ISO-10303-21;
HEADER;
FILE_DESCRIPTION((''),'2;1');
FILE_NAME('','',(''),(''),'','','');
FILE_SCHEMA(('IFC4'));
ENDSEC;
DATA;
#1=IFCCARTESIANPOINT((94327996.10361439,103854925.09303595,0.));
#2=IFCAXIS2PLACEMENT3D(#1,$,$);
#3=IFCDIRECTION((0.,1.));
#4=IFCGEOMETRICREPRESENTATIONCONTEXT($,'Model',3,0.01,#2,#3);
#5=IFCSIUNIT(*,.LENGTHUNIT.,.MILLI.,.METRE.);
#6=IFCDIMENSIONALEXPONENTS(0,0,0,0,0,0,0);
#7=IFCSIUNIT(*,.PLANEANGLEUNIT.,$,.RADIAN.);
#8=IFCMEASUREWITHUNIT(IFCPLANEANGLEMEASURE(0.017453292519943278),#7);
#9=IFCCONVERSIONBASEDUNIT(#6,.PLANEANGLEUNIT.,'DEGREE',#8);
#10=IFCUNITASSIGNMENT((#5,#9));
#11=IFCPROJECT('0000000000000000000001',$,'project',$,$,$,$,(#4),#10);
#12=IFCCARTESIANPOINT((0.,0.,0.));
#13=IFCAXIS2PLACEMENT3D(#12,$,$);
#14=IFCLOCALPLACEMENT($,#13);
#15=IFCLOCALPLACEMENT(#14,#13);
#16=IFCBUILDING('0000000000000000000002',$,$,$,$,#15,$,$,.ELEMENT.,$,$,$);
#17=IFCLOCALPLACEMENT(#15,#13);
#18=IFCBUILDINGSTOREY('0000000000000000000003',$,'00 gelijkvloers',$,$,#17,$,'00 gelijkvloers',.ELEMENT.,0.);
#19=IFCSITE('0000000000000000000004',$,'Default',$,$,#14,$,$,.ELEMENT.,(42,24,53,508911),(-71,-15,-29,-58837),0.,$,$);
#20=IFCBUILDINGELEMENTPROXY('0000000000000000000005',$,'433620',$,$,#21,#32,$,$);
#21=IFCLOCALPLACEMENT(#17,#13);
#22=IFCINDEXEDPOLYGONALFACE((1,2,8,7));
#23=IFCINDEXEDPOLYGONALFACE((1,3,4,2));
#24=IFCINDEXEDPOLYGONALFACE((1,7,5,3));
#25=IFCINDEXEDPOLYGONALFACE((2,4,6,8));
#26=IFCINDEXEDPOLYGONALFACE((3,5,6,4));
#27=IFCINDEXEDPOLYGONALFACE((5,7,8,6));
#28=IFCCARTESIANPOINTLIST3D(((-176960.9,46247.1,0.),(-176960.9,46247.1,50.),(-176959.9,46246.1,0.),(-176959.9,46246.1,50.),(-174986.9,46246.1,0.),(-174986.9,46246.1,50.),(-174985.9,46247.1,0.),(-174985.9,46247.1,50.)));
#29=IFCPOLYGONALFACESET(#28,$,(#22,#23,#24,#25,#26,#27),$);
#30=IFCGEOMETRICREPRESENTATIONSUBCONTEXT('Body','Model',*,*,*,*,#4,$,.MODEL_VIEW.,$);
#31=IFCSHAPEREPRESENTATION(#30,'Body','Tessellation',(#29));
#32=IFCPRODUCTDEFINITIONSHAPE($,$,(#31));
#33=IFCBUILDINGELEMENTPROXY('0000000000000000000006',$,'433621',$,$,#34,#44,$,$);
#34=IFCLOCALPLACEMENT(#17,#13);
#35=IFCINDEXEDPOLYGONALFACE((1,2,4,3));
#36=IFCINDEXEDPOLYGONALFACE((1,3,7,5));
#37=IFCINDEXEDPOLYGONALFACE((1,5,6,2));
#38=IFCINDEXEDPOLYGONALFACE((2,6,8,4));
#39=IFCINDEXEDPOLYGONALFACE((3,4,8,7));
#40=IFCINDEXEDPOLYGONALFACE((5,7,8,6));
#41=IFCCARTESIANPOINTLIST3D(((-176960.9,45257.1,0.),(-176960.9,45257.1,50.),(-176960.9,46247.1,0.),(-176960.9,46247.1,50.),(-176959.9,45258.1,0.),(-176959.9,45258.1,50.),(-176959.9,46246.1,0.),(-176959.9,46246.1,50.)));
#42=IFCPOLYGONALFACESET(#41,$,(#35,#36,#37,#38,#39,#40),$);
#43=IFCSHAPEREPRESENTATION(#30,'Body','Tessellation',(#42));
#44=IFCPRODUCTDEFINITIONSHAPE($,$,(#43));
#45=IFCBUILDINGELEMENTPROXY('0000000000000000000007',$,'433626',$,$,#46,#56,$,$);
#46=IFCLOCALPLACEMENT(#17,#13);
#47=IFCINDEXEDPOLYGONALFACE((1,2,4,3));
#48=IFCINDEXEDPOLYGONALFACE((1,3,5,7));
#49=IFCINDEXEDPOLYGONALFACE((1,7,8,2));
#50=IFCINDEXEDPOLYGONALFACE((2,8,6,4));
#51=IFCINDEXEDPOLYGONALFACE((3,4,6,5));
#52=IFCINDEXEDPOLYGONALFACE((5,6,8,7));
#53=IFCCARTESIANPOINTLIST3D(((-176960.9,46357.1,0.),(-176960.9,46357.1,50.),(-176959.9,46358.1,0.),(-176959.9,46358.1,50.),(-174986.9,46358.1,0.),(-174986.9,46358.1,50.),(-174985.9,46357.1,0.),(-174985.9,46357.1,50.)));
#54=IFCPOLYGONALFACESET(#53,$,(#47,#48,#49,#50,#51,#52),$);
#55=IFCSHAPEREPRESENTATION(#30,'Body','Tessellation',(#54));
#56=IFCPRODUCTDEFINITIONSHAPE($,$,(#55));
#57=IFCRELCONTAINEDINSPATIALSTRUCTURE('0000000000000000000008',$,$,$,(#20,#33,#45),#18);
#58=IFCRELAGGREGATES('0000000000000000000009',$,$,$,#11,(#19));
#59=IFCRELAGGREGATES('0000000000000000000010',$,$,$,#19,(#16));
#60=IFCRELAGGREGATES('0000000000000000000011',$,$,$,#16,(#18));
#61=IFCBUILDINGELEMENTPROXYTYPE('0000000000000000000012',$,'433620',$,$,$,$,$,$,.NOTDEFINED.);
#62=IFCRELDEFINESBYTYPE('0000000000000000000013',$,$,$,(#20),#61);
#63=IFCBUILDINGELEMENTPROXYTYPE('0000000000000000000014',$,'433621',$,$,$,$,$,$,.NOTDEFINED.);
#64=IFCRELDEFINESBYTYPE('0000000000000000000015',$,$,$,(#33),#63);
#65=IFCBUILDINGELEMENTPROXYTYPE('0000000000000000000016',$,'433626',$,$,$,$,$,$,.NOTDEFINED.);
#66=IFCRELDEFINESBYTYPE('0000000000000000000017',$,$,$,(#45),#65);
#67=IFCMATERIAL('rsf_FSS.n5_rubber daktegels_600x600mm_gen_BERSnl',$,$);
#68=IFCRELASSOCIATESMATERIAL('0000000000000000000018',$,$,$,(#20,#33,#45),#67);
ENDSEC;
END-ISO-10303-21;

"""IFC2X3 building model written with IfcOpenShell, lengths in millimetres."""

from ifc_helpers import new_model, entity, si_unit, converted_unit, direction, frame, origin, place, context, subcontext, project, spatial, polyline, outline, extrude, material, type_object, element, save


model = new_model("IFC2X3")

# Units and contexts
model_context = context("Model", 3, precision=0.01, world=frame((94327996.10361439, 103854925.09303595, 0.0)), true_north=direction((0.0, 1.0)))
body_context = subcontext(model_context, "Body", "Model", "MODEL_VIEW")
ifc_project = project(units=[si_unit("LENGTHUNIT", "METRE", prefix="MILLI"), converted_unit("PLANEANGLEUNIT", "DEGREE", entity("IfcPlaneAngleMeasure", 0.017453292519943278), si_unit("PLANEANGLEUNIT", "RADIAN"), dimensions=[0, 0, 0, 0, 0, 0, 0])], contexts=[model_context])

# Site, building, storey
site_placement = place(None, origin())
site = spatial("IfcSite", under=ifc_project, at=site_placement, Name="Default", CompositionType="ELEMENT", RefLatitude=(42, 24, 53, 508911), RefLongitude=(-71, -15, -29, -58837), RefElevation=0.0)
building_placement = place(site_placement, origin())
building = spatial("IfcBuilding", under=site, at=building_placement, CompositionType="ELEMENT")
storey_placement = place(building_placement, origin())
storey = spatial("IfcBuildingStorey", under=building, at=storey_placement, Name="00 gelijkvloers", LongName="00 gelijkvloers", CompositionType="ELEMENT", Elevation=0.0)

# Building element proxies
ifc_material = material(Name="rsf_FSS.n5_rubber daktegels_600x600mm_gen_BERSnl")
building_element_proxy_type_1 = type_object("IfcBuildingElementProxyType", Name="433620", PredefinedType="NOTDEFINED")
proxy_1_placement = place(storey_placement, origin())
element("IfcBuildingElementProxy", 1, at=proxy_1_placement, inside=storey, type_object=building_element_proxy_type_1, material=ifc_material, Name="433620", context=body_context, shape_type="SweptSolid", body=[
    extrude(outline(polyline([(-986.5, -0.5), (986.5, -0.5), (987.5, 0.5), (-987.5, 0.5), (-986.5, -0.5)])), frame((-175973.4, 46246.6, 0.0)), (0.0, 0.0, 1.0), 50.0),
])
building_element_proxy_type_2 = type_object("IfcBuildingElementProxyType", Name="433621", PredefinedType="NOTDEFINED")
proxy_2_placement = place(storey_placement, origin())
element("IfcBuildingElementProxy", 2, at=proxy_2_placement, inside=storey, type_object=building_element_proxy_type_2, material=ifc_material, Name="433621", context=body_context, shape_type="SweptSolid", body=[
    extrude(outline(polyline([(-494.0, -0.5), (494.0, -0.5), (495.0, 0.5), (-495.0, 0.5), (-494.0, -0.5)])), frame((-176960.4, 45752.1, 0.0), z_axis=(0.0, 0.0, 1.0), x_axis=(0.0, 1.0, 0.0)), (0.0, 0.0, 1.0), 50.0),
])
building_element_proxy_type_3 = type_object("IfcBuildingElementProxyType", Name="433626", PredefinedType="NOTDEFINED")
proxy_3_placement = place(storey_placement, origin())
element("IfcBuildingElementProxy", 3, at=proxy_3_placement, inside=storey, type_object=building_element_proxy_type_3, material=ifc_material, Name="433626", context=body_context, shape_type="SweptSolid", body=[
    extrude(outline(polyline([(-986.5, -0.5), (986.5, -0.5), (987.5, 0.5), (-987.5, 0.5), (-986.5, -0.5)])), frame((-175973.4, 46357.6, 0.0), z_axis=(0.0, 0.0, 1.0), x_axis=(-1.0, 0.0, 0.0)), (0.0, 0.0, 1.0), 50.0),
])

save(model, "model.ifc")
